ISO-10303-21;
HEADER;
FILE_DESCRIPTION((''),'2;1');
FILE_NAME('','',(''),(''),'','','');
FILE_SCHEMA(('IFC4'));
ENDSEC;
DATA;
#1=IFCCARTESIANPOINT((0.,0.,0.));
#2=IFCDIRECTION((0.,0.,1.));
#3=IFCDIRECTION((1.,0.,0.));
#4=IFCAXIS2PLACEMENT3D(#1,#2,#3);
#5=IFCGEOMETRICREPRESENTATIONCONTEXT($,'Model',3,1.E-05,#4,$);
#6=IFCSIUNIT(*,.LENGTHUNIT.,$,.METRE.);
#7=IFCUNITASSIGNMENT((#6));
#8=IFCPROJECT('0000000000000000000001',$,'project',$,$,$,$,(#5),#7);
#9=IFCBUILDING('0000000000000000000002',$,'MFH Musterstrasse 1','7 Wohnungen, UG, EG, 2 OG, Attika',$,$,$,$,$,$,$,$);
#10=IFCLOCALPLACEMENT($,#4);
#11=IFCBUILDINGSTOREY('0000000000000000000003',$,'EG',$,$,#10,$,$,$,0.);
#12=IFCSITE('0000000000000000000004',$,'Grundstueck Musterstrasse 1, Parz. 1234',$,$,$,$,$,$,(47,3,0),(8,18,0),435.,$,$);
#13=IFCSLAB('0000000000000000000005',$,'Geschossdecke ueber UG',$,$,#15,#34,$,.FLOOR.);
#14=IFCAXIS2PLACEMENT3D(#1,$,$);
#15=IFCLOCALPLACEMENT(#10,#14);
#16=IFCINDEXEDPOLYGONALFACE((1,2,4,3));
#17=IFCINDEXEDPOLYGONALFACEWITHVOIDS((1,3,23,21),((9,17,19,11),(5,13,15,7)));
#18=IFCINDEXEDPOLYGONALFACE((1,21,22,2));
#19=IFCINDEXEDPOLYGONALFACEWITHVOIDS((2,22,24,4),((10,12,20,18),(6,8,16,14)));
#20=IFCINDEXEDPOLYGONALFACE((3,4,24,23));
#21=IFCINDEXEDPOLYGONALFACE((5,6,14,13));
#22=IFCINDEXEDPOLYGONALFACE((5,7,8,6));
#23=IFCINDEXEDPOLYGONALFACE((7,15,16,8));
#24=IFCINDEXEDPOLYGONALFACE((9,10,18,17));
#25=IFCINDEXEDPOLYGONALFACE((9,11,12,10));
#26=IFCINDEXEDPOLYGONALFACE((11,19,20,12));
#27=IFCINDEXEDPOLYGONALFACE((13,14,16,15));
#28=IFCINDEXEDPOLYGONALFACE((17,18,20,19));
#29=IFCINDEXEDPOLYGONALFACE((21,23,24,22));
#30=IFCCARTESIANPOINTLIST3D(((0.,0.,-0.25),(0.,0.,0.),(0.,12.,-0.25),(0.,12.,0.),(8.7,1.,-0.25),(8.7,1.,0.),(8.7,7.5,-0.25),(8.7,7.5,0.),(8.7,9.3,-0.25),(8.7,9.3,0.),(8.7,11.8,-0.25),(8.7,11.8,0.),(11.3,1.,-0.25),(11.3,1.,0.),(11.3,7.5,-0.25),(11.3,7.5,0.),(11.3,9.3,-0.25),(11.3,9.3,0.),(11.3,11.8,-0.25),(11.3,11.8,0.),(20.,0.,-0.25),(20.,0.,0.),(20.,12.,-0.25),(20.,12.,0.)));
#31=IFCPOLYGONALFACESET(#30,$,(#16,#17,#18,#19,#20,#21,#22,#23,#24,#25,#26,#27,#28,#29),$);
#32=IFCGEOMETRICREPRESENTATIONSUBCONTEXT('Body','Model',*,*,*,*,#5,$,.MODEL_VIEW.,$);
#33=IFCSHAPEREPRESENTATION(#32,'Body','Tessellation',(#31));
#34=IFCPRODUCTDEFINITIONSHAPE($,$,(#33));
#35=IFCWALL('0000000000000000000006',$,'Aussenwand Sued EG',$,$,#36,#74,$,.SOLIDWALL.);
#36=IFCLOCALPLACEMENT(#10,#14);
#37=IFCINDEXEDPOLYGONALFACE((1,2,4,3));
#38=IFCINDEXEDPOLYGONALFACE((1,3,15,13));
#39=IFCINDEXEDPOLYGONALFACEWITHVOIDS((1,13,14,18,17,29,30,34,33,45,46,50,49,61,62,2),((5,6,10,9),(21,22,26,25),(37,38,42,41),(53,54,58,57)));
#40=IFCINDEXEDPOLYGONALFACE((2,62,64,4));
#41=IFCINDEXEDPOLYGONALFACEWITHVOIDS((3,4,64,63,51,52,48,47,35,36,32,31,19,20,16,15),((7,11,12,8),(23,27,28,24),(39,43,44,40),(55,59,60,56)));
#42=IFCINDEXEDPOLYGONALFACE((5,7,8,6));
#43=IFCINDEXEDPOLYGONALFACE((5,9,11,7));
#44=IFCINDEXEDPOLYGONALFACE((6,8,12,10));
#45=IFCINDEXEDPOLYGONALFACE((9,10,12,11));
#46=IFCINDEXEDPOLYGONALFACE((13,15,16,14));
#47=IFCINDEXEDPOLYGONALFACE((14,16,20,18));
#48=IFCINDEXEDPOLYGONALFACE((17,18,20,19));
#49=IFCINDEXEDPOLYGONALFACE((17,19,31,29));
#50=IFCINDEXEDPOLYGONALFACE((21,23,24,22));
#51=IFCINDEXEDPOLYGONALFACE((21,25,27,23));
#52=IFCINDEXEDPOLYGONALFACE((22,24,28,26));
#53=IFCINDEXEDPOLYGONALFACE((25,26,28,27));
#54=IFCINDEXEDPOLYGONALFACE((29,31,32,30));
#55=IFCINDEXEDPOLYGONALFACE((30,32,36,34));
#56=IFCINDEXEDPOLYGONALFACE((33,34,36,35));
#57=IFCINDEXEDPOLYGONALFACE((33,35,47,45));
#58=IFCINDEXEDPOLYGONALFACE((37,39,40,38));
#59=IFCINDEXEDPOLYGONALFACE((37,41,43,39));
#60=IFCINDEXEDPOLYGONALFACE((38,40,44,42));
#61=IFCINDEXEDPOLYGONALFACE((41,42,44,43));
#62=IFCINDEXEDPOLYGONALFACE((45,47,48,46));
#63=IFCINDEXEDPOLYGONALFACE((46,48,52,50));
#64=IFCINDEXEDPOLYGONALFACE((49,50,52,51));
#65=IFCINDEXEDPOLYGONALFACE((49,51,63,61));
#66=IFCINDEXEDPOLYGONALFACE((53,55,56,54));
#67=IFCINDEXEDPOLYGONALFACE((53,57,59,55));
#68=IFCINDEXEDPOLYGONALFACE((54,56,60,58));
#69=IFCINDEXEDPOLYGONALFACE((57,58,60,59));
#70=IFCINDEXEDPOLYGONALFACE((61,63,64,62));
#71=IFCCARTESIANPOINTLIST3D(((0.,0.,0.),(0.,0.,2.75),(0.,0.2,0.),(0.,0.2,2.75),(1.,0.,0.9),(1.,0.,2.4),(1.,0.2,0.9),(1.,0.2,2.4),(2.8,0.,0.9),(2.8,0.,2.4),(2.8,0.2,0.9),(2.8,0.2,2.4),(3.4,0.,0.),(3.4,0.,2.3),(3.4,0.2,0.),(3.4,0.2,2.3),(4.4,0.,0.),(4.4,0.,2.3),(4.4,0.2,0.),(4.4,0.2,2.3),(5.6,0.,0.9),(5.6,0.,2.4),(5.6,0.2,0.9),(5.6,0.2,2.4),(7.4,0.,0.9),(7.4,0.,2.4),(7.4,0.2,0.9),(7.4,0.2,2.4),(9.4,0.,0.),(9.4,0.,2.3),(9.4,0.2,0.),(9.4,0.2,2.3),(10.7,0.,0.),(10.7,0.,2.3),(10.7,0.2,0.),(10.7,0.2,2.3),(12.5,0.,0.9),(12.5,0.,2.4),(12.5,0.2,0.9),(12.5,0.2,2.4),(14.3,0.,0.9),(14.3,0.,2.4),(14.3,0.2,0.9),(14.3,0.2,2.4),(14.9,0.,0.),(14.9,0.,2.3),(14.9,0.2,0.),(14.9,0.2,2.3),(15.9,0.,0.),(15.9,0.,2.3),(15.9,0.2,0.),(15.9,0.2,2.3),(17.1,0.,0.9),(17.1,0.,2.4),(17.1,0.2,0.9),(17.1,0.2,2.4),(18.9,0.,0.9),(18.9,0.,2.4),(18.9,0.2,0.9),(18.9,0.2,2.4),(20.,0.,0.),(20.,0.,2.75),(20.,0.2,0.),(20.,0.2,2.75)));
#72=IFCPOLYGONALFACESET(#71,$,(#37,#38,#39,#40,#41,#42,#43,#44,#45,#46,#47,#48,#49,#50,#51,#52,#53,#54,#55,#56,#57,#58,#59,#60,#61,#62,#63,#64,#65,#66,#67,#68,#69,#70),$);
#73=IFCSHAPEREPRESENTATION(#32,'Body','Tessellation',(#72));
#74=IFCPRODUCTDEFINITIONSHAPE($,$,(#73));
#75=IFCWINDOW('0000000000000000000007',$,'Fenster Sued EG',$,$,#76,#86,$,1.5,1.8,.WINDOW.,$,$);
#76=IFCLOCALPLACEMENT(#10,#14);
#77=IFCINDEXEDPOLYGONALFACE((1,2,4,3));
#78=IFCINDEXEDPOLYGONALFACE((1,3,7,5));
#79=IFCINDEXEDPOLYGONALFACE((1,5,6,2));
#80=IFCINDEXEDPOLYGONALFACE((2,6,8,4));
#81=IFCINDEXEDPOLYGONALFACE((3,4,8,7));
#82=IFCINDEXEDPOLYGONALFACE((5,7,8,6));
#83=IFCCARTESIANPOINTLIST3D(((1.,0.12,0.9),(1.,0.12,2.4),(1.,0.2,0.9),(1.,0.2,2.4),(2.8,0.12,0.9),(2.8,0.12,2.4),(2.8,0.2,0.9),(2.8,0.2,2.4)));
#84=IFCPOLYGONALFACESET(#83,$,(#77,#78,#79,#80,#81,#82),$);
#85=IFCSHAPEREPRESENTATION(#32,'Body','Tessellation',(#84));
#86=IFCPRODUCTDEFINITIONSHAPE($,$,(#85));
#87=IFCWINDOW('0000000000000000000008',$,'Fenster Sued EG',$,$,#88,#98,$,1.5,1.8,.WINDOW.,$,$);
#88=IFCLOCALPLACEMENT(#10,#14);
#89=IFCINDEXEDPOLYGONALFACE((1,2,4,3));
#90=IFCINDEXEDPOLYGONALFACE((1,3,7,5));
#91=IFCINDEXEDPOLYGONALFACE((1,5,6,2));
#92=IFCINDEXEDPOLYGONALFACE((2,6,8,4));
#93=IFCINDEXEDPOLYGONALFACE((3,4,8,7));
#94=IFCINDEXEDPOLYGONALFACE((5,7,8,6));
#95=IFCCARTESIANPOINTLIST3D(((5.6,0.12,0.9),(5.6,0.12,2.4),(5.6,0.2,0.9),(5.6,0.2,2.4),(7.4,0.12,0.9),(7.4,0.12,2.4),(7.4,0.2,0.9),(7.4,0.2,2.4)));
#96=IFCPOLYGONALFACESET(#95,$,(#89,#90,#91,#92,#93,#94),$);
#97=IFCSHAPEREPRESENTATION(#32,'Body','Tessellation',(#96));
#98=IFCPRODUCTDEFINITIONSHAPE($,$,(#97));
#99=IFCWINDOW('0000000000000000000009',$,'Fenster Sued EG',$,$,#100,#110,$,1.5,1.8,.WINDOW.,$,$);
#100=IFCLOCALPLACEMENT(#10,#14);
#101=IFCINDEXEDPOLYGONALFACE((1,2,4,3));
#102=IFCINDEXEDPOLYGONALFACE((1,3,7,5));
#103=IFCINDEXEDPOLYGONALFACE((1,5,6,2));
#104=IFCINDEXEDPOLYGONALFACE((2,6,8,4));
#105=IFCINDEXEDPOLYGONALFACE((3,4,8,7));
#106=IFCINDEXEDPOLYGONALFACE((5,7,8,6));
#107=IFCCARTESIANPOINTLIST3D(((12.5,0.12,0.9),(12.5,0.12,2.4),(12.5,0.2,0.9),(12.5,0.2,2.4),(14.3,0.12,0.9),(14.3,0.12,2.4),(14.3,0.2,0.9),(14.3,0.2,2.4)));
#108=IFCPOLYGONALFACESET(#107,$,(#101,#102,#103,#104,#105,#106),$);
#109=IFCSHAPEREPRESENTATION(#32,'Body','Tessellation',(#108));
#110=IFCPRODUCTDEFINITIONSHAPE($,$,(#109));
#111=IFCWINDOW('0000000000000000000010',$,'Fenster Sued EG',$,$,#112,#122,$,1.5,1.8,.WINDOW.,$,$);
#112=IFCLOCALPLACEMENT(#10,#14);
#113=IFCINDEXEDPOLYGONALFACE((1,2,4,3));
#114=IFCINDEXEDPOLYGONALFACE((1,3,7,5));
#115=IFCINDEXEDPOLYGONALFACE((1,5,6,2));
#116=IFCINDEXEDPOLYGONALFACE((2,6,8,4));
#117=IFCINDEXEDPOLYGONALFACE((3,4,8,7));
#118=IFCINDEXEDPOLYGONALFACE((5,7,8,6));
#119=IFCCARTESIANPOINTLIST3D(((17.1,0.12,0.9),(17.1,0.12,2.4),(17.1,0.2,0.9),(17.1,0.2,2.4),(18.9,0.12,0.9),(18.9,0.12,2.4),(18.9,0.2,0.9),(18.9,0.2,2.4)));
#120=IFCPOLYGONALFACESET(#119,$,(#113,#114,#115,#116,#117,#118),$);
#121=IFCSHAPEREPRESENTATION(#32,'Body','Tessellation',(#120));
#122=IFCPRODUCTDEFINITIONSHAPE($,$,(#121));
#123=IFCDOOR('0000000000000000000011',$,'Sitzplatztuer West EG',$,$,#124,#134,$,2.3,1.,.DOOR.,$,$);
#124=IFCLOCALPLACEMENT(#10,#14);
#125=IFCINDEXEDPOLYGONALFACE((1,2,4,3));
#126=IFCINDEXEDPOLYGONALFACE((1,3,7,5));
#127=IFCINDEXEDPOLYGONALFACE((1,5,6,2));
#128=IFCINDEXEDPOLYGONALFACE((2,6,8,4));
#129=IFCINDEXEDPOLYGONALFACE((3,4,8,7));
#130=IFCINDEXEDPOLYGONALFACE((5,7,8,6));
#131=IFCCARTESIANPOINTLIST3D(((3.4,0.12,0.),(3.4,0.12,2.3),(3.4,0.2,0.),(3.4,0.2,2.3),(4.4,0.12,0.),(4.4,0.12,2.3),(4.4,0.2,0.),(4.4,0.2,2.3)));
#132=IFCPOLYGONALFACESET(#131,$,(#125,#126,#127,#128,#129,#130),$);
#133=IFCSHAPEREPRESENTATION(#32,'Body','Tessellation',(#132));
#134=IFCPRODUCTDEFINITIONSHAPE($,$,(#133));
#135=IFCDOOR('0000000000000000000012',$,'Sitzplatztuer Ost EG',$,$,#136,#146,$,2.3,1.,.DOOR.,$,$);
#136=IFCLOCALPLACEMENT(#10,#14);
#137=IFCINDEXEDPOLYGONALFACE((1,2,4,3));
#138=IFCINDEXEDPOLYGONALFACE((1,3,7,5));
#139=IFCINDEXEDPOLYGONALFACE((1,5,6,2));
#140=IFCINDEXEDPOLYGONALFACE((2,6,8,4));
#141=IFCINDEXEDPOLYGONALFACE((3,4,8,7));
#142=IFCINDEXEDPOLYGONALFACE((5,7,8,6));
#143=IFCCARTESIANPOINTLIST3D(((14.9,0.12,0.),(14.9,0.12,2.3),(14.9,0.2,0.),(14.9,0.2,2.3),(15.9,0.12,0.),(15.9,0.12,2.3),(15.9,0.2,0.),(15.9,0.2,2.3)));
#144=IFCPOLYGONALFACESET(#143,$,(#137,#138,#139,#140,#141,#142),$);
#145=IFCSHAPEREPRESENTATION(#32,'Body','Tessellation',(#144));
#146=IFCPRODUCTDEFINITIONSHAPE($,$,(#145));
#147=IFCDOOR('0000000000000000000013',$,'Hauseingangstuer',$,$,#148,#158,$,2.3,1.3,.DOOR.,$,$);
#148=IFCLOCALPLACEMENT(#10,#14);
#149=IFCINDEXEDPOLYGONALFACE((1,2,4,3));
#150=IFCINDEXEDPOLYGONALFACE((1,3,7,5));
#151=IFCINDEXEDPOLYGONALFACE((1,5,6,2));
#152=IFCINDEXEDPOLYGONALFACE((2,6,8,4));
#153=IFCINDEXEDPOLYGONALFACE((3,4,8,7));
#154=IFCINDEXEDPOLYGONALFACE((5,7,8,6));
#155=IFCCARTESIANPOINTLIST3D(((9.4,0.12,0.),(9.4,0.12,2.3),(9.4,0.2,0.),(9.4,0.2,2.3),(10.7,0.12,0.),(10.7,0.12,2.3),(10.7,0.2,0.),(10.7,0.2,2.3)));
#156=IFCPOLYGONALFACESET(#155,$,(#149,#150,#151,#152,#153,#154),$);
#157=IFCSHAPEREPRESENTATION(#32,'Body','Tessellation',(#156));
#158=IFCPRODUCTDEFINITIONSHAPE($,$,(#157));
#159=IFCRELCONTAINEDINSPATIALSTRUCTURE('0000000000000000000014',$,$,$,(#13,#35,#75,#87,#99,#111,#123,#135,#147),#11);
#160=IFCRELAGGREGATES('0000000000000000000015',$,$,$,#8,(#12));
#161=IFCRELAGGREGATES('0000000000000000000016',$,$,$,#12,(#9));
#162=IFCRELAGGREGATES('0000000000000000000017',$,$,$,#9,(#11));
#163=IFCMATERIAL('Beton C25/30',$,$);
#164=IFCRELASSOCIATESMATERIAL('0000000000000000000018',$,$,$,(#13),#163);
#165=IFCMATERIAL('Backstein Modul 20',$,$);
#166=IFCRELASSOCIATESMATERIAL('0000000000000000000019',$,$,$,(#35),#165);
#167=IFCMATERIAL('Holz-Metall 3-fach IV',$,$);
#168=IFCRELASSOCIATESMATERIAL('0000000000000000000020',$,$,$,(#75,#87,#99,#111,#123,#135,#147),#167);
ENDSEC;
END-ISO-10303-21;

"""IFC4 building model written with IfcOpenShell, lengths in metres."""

from ifc_helpers import new_model, si_unit, frame, frame_2d, origin_with_axes, place, context, subcontext, project, spatial, polyline, rectangle, outline, extrude, material, element, fill, save


model = new_model("IFC4")

# Units and contexts
model_context = context("Model", 3, precision=1e-05, world=origin_with_axes())
body_context = subcontext(model_context, "Body", "Model", "MODEL_VIEW")
ifc_project = project(units=[si_unit("LENGTHUNIT", "METRE")], contexts=[model_context])

# Site, building, storey
site = spatial("IfcSite", under=ifc_project, Name="Grundstueck Musterstrasse 1, Parz. 1234", RefLatitude=(47, 3, 0), RefLongitude=(8, 18, 0), RefElevation=435.0)
building = spatial("IfcBuilding", under=site, Name="MFH Musterstrasse 1", Description="7 Wohnungen, UG, EG, 2 OG, Attika")
storey_placement = place(None, origin_with_axes())
storey = spatial("IfcBuildingStorey", under=building, at=storey_placement, Name="EG", Elevation=0.0)

# Slab, openings
ifc_material_1 = material(Name="Beton C25/30")
slab_placement = place(storey_placement, frame((0.0, 0.0, -0.25), z_axis=(0.0, 0.0, 1.0), x_axis=(1.0, 0.0, 0.0)))
slab = element("IfcSlab", 1, at=slab_placement, inside=storey, material=ifc_material_1, Name="Geschossdecke ueber UG", PredefinedType="FLOOR", context=body_context, shape_type="SweptSolid", body=[
    extrude(outline(polyline([(0.0, 0.0), (20.0, 0.0), (20.0, 12.0), (0.0, 12.0), (0.0, 0.0)])), origin_with_axes(), (0.0, 0.0, 1.0), 0.25),
])
opening_1_placement = place(slab_placement, frame((8.7, 1.0, -0.01), z_axis=(0.0, 0.0, 1.0), x_axis=(1.0, 0.0, 0.0)))
element("IfcOpeningElement", 2, at=opening_1_placement, cuts=slab, context=body_context, shape_type="SweptSolid", body=[
    extrude(rectangle(XDim=2.6, YDim=6.5, at=frame_2d((1.3, 3.25))), origin_with_axes(), (0.0, 0.0, 1.0), 0.27),
])
opening_2_placement = place(slab_placement, frame((8.7, 9.3, -0.01), z_axis=(0.0, 0.0, 1.0), x_axis=(1.0, 0.0, 0.0)))
element("IfcOpeningElement", 3, at=opening_2_placement, cuts=slab, context=body_context, shape_type="SweptSolid", body=[
    extrude(rectangle(XDim=2.6, YDim=2.5, at=frame_2d((1.3, 1.25))), origin_with_axes(), (0.0, 0.0, 1.0), 0.27),
])

# Wall, openings, windows, doors
ifc_material_2 = material(Name="Backstein Modul 20")
wall_1_placement = place(storey_placement, origin_with_axes())
wall_1 = element("IfcWall", 4, at=wall_1_placement, inside=storey, material=ifc_material_2, Name="Aussenwand Sued EG", PredefinedType="SOLIDWALL", context=body_context, shape_type="SweptSolid", body=[
    extrude(rectangle(XDim=20.0, YDim=0.2, at=frame_2d((10.0, 0.1))), origin_with_axes(), (0.0, 0.0, 1.0), 2.75),
])
opening_3_placement = place(wall_1_placement, frame((1.0, -0.21, 0.9), z_axis=(0.0, 0.0, 1.0), x_axis=(1.0, 0.0, 0.0)))
opening_3 = element("IfcOpeningElement", 5, at=opening_3_placement, cuts=wall_1, context=body_context, shape_type="SweptSolid", body=[
    extrude(rectangle(XDim=1.8, YDim=0.42, at=frame_2d((0.9, 0.21))), origin_with_axes(), (0.0, 0.0, 1.0), 1.5),
])
opening_4_placement = place(wall_1_placement, frame((5.6, -0.21, 0.9), z_axis=(0.0, 0.0, 1.0), x_axis=(1.0, 0.0, 0.0)))
opening_4 = element("IfcOpeningElement", 6, at=opening_4_placement, cuts=wall_1, context=body_context, shape_type="SweptSolid", body=[
    extrude(rectangle(XDim=1.8, YDim=0.42, at=frame_2d((0.9, 0.21))), origin_with_axes(), (0.0, 0.0, 1.0), 1.5),
])
opening_5_placement = place(wall_1_placement, frame((12.5, -0.21, 0.9), z_axis=(0.0, 0.0, 1.0), x_axis=(1.0, 0.0, 0.0)))
opening_5 = element("IfcOpeningElement", 7, at=opening_5_placement, cuts=wall_1, context=body_context, shape_type="SweptSolid", body=[
    extrude(rectangle(XDim=1.8, YDim=0.42, at=frame_2d((0.9, 0.21))), origin_with_axes(), (0.0, 0.0, 1.0), 1.5),
])
opening_6_placement = place(wall_1_placement, frame((17.1, -0.21, 0.9), z_axis=(0.0, 0.0, 1.0), x_axis=(1.0, 0.0, 0.0)))
opening_6 = element("IfcOpeningElement", 8, at=opening_6_placement, cuts=wall_1, context=body_context, shape_type="SweptSolid", body=[
    extrude(rectangle(XDim=1.8, YDim=0.42, at=frame_2d((0.9, 0.21))), origin_with_axes(), (0.0, 0.0, 1.0), 1.5),
])
opening_7_placement = place(wall_1_placement, frame((3.4, -0.21, 0.0), z_axis=(0.0, 0.0, 1.0), x_axis=(1.0, 0.0, 0.0)))
opening_7 = element("IfcOpeningElement", 9, at=opening_7_placement, cuts=wall_1, context=body_context, shape_type="SweptSolid", body=[
    extrude(rectangle(XDim=1.0, YDim=0.42, at=frame_2d((0.5, 0.21))), origin_with_axes(), (0.0, 0.0, 1.0), 2.3),
])
opening_8_placement = place(wall_1_placement, frame((14.9, -0.21, 0.0), z_axis=(0.0, 0.0, 1.0), x_axis=(1.0, 0.0, 0.0)))
opening_8 = element("IfcOpeningElement", 10, at=opening_8_placement, cuts=wall_1, context=body_context, shape_type="SweptSolid", body=[
    extrude(rectangle(XDim=1.0, YDim=0.42, at=frame_2d((0.5, 0.21))), origin_with_axes(), (0.0, 0.0, 1.0), 2.3),
])
opening_9_placement = place(wall_1_placement, frame((9.4, -0.21, 0.0), z_axis=(0.0, 0.0, 1.0), x_axis=(1.0, 0.0, 0.0)))
opening_9 = element("IfcOpeningElement", 11, at=opening_9_placement, cuts=wall_1, context=body_context, shape_type="SweptSolid", body=[
    extrude(rectangle(XDim=1.3, YDim=0.42, at=frame_2d((0.65, 0.21))), origin_with_axes(), (0.0, 0.0, 1.0), 2.3),
])
ifc_material_3 = material(Name="Holz-Metall 3-fach IV")
window_1_placement = place(storey_placement, frame((1.0, 0.12, 0.9), z_axis=(0.0, 0.0, 1.0), x_axis=(1.0, 0.0, 0.0)))
window_1 = element("IfcWindow", 12, at=window_1_placement, inside=storey, material=ifc_material_3, Name="Fenster Sued EG", OverallHeight=1.5, OverallWidth=1.8, PredefinedType="WINDOW", context=body_context, shape_type="SweptSolid", body=[
    extrude(rectangle(XDim=1.8, YDim=0.08, at=frame_2d((0.9, 0.04))), origin_with_axes(), (0.0, 0.0, 1.0), 1.5),
])
fill(opening_3, window_1)
window_2_placement = place(storey_placement, frame((5.6, 0.12, 0.9), z_axis=(0.0, 0.0, 1.0), x_axis=(1.0, 0.0, 0.0)))
window_2 = element("IfcWindow", 13, at=window_2_placement, inside=storey, material=ifc_material_3, Name="Fenster Sued EG", OverallHeight=1.5, OverallWidth=1.8, PredefinedType="WINDOW", context=body_context, shape_type="SweptSolid", body=[
    extrude(rectangle(XDim=1.8, YDim=0.08, at=frame_2d((0.9, 0.04))), origin_with_axes(), (0.0, 0.0, 1.0), 1.5),
])
fill(opening_4, window_2)
window_3_placement = place(storey_placement, frame((12.5, 0.12, 0.9), z_axis=(0.0, 0.0, 1.0), x_axis=(1.0, 0.0, 0.0)))
window_3 = element("IfcWindow", 14, at=window_3_placement, inside=storey, material=ifc_material_3, Name="Fenster Sued EG", OverallHeight=1.5, OverallWidth=1.8, PredefinedType="WINDOW", context=body_context, shape_type="SweptSolid", body=[
    extrude(rectangle(XDim=1.8, YDim=0.08, at=frame_2d((0.9, 0.04))), origin_with_axes(), (0.0, 0.0, 1.0), 1.5),
])
fill(opening_5, window_3)
window_4_placement = place(storey_placement, frame((17.1, 0.12, 0.9), z_axis=(0.0, 0.0, 1.0), x_axis=(1.0, 0.0, 0.0)))
window_4 = element("IfcWindow", 15, at=window_4_placement, inside=storey, material=ifc_material_3, Name="Fenster Sued EG", OverallHeight=1.5, OverallWidth=1.8, PredefinedType="WINDOW", context=body_context, shape_type="SweptSolid", body=[
    extrude(rectangle(XDim=1.8, YDim=0.08, at=frame_2d((0.9, 0.04))), origin_with_axes(), (0.0, 0.0, 1.0), 1.5),
])
fill(opening_6, window_4)
door_1_placement = place(storey_placement, frame((3.4, 0.12, 0.0), z_axis=(0.0, 0.0, 1.0), x_axis=(1.0, 0.0, 0.0)))
door_1 = element("IfcDoor", 16, at=door_1_placement, inside=storey, material=ifc_material_3, Name="Sitzplatztuer West EG", OverallHeight=2.3, OverallWidth=1.0, PredefinedType="DOOR", context=body_context, shape_type="SweptSolid", body=[
    extrude(rectangle(XDim=1.0, YDim=0.08, at=frame_2d((0.5, 0.04))), origin_with_axes(), (0.0, 0.0, 1.0), 2.3),
])
fill(opening_7, door_1)
door_2_placement = place(storey_placement, frame((14.9, 0.12, 0.0), z_axis=(0.0, 0.0, 1.0), x_axis=(1.0, 0.0, 0.0)))
door_2 = element("IfcDoor", 17, at=door_2_placement, inside=storey, material=ifc_material_3, Name="Sitzplatztuer Ost EG", OverallHeight=2.3, OverallWidth=1.0, PredefinedType="DOOR", context=body_context, shape_type="SweptSolid", body=[
    extrude(rectangle(XDim=1.0, YDim=0.08, at=frame_2d((0.5, 0.04))), origin_with_axes(), (0.0, 0.0, 1.0), 2.3),
])
fill(opening_8, door_2)
door_3_placement = place(storey_placement, frame((9.4, 0.12, 0.0), z_axis=(0.0, 0.0, 1.0), x_axis=(1.0, 0.0, 0.0)))
door_3 = element("IfcDoor", 18, at=door_3_placement, inside=storey, material=ifc_material_3, Name="Hauseingangstuer", OverallHeight=2.3, OverallWidth=1.3, PredefinedType="DOOR", context=body_context, shape_type="SweptSolid", body=[
    extrude(rectangle(XDim=1.3, YDim=0.08, at=frame_2d((0.65, 0.04))), origin_with_axes(), (0.0, 0.0, 1.0), 2.3),
])
fill(opening_9, door_3)

save(model, "model.ifc")
